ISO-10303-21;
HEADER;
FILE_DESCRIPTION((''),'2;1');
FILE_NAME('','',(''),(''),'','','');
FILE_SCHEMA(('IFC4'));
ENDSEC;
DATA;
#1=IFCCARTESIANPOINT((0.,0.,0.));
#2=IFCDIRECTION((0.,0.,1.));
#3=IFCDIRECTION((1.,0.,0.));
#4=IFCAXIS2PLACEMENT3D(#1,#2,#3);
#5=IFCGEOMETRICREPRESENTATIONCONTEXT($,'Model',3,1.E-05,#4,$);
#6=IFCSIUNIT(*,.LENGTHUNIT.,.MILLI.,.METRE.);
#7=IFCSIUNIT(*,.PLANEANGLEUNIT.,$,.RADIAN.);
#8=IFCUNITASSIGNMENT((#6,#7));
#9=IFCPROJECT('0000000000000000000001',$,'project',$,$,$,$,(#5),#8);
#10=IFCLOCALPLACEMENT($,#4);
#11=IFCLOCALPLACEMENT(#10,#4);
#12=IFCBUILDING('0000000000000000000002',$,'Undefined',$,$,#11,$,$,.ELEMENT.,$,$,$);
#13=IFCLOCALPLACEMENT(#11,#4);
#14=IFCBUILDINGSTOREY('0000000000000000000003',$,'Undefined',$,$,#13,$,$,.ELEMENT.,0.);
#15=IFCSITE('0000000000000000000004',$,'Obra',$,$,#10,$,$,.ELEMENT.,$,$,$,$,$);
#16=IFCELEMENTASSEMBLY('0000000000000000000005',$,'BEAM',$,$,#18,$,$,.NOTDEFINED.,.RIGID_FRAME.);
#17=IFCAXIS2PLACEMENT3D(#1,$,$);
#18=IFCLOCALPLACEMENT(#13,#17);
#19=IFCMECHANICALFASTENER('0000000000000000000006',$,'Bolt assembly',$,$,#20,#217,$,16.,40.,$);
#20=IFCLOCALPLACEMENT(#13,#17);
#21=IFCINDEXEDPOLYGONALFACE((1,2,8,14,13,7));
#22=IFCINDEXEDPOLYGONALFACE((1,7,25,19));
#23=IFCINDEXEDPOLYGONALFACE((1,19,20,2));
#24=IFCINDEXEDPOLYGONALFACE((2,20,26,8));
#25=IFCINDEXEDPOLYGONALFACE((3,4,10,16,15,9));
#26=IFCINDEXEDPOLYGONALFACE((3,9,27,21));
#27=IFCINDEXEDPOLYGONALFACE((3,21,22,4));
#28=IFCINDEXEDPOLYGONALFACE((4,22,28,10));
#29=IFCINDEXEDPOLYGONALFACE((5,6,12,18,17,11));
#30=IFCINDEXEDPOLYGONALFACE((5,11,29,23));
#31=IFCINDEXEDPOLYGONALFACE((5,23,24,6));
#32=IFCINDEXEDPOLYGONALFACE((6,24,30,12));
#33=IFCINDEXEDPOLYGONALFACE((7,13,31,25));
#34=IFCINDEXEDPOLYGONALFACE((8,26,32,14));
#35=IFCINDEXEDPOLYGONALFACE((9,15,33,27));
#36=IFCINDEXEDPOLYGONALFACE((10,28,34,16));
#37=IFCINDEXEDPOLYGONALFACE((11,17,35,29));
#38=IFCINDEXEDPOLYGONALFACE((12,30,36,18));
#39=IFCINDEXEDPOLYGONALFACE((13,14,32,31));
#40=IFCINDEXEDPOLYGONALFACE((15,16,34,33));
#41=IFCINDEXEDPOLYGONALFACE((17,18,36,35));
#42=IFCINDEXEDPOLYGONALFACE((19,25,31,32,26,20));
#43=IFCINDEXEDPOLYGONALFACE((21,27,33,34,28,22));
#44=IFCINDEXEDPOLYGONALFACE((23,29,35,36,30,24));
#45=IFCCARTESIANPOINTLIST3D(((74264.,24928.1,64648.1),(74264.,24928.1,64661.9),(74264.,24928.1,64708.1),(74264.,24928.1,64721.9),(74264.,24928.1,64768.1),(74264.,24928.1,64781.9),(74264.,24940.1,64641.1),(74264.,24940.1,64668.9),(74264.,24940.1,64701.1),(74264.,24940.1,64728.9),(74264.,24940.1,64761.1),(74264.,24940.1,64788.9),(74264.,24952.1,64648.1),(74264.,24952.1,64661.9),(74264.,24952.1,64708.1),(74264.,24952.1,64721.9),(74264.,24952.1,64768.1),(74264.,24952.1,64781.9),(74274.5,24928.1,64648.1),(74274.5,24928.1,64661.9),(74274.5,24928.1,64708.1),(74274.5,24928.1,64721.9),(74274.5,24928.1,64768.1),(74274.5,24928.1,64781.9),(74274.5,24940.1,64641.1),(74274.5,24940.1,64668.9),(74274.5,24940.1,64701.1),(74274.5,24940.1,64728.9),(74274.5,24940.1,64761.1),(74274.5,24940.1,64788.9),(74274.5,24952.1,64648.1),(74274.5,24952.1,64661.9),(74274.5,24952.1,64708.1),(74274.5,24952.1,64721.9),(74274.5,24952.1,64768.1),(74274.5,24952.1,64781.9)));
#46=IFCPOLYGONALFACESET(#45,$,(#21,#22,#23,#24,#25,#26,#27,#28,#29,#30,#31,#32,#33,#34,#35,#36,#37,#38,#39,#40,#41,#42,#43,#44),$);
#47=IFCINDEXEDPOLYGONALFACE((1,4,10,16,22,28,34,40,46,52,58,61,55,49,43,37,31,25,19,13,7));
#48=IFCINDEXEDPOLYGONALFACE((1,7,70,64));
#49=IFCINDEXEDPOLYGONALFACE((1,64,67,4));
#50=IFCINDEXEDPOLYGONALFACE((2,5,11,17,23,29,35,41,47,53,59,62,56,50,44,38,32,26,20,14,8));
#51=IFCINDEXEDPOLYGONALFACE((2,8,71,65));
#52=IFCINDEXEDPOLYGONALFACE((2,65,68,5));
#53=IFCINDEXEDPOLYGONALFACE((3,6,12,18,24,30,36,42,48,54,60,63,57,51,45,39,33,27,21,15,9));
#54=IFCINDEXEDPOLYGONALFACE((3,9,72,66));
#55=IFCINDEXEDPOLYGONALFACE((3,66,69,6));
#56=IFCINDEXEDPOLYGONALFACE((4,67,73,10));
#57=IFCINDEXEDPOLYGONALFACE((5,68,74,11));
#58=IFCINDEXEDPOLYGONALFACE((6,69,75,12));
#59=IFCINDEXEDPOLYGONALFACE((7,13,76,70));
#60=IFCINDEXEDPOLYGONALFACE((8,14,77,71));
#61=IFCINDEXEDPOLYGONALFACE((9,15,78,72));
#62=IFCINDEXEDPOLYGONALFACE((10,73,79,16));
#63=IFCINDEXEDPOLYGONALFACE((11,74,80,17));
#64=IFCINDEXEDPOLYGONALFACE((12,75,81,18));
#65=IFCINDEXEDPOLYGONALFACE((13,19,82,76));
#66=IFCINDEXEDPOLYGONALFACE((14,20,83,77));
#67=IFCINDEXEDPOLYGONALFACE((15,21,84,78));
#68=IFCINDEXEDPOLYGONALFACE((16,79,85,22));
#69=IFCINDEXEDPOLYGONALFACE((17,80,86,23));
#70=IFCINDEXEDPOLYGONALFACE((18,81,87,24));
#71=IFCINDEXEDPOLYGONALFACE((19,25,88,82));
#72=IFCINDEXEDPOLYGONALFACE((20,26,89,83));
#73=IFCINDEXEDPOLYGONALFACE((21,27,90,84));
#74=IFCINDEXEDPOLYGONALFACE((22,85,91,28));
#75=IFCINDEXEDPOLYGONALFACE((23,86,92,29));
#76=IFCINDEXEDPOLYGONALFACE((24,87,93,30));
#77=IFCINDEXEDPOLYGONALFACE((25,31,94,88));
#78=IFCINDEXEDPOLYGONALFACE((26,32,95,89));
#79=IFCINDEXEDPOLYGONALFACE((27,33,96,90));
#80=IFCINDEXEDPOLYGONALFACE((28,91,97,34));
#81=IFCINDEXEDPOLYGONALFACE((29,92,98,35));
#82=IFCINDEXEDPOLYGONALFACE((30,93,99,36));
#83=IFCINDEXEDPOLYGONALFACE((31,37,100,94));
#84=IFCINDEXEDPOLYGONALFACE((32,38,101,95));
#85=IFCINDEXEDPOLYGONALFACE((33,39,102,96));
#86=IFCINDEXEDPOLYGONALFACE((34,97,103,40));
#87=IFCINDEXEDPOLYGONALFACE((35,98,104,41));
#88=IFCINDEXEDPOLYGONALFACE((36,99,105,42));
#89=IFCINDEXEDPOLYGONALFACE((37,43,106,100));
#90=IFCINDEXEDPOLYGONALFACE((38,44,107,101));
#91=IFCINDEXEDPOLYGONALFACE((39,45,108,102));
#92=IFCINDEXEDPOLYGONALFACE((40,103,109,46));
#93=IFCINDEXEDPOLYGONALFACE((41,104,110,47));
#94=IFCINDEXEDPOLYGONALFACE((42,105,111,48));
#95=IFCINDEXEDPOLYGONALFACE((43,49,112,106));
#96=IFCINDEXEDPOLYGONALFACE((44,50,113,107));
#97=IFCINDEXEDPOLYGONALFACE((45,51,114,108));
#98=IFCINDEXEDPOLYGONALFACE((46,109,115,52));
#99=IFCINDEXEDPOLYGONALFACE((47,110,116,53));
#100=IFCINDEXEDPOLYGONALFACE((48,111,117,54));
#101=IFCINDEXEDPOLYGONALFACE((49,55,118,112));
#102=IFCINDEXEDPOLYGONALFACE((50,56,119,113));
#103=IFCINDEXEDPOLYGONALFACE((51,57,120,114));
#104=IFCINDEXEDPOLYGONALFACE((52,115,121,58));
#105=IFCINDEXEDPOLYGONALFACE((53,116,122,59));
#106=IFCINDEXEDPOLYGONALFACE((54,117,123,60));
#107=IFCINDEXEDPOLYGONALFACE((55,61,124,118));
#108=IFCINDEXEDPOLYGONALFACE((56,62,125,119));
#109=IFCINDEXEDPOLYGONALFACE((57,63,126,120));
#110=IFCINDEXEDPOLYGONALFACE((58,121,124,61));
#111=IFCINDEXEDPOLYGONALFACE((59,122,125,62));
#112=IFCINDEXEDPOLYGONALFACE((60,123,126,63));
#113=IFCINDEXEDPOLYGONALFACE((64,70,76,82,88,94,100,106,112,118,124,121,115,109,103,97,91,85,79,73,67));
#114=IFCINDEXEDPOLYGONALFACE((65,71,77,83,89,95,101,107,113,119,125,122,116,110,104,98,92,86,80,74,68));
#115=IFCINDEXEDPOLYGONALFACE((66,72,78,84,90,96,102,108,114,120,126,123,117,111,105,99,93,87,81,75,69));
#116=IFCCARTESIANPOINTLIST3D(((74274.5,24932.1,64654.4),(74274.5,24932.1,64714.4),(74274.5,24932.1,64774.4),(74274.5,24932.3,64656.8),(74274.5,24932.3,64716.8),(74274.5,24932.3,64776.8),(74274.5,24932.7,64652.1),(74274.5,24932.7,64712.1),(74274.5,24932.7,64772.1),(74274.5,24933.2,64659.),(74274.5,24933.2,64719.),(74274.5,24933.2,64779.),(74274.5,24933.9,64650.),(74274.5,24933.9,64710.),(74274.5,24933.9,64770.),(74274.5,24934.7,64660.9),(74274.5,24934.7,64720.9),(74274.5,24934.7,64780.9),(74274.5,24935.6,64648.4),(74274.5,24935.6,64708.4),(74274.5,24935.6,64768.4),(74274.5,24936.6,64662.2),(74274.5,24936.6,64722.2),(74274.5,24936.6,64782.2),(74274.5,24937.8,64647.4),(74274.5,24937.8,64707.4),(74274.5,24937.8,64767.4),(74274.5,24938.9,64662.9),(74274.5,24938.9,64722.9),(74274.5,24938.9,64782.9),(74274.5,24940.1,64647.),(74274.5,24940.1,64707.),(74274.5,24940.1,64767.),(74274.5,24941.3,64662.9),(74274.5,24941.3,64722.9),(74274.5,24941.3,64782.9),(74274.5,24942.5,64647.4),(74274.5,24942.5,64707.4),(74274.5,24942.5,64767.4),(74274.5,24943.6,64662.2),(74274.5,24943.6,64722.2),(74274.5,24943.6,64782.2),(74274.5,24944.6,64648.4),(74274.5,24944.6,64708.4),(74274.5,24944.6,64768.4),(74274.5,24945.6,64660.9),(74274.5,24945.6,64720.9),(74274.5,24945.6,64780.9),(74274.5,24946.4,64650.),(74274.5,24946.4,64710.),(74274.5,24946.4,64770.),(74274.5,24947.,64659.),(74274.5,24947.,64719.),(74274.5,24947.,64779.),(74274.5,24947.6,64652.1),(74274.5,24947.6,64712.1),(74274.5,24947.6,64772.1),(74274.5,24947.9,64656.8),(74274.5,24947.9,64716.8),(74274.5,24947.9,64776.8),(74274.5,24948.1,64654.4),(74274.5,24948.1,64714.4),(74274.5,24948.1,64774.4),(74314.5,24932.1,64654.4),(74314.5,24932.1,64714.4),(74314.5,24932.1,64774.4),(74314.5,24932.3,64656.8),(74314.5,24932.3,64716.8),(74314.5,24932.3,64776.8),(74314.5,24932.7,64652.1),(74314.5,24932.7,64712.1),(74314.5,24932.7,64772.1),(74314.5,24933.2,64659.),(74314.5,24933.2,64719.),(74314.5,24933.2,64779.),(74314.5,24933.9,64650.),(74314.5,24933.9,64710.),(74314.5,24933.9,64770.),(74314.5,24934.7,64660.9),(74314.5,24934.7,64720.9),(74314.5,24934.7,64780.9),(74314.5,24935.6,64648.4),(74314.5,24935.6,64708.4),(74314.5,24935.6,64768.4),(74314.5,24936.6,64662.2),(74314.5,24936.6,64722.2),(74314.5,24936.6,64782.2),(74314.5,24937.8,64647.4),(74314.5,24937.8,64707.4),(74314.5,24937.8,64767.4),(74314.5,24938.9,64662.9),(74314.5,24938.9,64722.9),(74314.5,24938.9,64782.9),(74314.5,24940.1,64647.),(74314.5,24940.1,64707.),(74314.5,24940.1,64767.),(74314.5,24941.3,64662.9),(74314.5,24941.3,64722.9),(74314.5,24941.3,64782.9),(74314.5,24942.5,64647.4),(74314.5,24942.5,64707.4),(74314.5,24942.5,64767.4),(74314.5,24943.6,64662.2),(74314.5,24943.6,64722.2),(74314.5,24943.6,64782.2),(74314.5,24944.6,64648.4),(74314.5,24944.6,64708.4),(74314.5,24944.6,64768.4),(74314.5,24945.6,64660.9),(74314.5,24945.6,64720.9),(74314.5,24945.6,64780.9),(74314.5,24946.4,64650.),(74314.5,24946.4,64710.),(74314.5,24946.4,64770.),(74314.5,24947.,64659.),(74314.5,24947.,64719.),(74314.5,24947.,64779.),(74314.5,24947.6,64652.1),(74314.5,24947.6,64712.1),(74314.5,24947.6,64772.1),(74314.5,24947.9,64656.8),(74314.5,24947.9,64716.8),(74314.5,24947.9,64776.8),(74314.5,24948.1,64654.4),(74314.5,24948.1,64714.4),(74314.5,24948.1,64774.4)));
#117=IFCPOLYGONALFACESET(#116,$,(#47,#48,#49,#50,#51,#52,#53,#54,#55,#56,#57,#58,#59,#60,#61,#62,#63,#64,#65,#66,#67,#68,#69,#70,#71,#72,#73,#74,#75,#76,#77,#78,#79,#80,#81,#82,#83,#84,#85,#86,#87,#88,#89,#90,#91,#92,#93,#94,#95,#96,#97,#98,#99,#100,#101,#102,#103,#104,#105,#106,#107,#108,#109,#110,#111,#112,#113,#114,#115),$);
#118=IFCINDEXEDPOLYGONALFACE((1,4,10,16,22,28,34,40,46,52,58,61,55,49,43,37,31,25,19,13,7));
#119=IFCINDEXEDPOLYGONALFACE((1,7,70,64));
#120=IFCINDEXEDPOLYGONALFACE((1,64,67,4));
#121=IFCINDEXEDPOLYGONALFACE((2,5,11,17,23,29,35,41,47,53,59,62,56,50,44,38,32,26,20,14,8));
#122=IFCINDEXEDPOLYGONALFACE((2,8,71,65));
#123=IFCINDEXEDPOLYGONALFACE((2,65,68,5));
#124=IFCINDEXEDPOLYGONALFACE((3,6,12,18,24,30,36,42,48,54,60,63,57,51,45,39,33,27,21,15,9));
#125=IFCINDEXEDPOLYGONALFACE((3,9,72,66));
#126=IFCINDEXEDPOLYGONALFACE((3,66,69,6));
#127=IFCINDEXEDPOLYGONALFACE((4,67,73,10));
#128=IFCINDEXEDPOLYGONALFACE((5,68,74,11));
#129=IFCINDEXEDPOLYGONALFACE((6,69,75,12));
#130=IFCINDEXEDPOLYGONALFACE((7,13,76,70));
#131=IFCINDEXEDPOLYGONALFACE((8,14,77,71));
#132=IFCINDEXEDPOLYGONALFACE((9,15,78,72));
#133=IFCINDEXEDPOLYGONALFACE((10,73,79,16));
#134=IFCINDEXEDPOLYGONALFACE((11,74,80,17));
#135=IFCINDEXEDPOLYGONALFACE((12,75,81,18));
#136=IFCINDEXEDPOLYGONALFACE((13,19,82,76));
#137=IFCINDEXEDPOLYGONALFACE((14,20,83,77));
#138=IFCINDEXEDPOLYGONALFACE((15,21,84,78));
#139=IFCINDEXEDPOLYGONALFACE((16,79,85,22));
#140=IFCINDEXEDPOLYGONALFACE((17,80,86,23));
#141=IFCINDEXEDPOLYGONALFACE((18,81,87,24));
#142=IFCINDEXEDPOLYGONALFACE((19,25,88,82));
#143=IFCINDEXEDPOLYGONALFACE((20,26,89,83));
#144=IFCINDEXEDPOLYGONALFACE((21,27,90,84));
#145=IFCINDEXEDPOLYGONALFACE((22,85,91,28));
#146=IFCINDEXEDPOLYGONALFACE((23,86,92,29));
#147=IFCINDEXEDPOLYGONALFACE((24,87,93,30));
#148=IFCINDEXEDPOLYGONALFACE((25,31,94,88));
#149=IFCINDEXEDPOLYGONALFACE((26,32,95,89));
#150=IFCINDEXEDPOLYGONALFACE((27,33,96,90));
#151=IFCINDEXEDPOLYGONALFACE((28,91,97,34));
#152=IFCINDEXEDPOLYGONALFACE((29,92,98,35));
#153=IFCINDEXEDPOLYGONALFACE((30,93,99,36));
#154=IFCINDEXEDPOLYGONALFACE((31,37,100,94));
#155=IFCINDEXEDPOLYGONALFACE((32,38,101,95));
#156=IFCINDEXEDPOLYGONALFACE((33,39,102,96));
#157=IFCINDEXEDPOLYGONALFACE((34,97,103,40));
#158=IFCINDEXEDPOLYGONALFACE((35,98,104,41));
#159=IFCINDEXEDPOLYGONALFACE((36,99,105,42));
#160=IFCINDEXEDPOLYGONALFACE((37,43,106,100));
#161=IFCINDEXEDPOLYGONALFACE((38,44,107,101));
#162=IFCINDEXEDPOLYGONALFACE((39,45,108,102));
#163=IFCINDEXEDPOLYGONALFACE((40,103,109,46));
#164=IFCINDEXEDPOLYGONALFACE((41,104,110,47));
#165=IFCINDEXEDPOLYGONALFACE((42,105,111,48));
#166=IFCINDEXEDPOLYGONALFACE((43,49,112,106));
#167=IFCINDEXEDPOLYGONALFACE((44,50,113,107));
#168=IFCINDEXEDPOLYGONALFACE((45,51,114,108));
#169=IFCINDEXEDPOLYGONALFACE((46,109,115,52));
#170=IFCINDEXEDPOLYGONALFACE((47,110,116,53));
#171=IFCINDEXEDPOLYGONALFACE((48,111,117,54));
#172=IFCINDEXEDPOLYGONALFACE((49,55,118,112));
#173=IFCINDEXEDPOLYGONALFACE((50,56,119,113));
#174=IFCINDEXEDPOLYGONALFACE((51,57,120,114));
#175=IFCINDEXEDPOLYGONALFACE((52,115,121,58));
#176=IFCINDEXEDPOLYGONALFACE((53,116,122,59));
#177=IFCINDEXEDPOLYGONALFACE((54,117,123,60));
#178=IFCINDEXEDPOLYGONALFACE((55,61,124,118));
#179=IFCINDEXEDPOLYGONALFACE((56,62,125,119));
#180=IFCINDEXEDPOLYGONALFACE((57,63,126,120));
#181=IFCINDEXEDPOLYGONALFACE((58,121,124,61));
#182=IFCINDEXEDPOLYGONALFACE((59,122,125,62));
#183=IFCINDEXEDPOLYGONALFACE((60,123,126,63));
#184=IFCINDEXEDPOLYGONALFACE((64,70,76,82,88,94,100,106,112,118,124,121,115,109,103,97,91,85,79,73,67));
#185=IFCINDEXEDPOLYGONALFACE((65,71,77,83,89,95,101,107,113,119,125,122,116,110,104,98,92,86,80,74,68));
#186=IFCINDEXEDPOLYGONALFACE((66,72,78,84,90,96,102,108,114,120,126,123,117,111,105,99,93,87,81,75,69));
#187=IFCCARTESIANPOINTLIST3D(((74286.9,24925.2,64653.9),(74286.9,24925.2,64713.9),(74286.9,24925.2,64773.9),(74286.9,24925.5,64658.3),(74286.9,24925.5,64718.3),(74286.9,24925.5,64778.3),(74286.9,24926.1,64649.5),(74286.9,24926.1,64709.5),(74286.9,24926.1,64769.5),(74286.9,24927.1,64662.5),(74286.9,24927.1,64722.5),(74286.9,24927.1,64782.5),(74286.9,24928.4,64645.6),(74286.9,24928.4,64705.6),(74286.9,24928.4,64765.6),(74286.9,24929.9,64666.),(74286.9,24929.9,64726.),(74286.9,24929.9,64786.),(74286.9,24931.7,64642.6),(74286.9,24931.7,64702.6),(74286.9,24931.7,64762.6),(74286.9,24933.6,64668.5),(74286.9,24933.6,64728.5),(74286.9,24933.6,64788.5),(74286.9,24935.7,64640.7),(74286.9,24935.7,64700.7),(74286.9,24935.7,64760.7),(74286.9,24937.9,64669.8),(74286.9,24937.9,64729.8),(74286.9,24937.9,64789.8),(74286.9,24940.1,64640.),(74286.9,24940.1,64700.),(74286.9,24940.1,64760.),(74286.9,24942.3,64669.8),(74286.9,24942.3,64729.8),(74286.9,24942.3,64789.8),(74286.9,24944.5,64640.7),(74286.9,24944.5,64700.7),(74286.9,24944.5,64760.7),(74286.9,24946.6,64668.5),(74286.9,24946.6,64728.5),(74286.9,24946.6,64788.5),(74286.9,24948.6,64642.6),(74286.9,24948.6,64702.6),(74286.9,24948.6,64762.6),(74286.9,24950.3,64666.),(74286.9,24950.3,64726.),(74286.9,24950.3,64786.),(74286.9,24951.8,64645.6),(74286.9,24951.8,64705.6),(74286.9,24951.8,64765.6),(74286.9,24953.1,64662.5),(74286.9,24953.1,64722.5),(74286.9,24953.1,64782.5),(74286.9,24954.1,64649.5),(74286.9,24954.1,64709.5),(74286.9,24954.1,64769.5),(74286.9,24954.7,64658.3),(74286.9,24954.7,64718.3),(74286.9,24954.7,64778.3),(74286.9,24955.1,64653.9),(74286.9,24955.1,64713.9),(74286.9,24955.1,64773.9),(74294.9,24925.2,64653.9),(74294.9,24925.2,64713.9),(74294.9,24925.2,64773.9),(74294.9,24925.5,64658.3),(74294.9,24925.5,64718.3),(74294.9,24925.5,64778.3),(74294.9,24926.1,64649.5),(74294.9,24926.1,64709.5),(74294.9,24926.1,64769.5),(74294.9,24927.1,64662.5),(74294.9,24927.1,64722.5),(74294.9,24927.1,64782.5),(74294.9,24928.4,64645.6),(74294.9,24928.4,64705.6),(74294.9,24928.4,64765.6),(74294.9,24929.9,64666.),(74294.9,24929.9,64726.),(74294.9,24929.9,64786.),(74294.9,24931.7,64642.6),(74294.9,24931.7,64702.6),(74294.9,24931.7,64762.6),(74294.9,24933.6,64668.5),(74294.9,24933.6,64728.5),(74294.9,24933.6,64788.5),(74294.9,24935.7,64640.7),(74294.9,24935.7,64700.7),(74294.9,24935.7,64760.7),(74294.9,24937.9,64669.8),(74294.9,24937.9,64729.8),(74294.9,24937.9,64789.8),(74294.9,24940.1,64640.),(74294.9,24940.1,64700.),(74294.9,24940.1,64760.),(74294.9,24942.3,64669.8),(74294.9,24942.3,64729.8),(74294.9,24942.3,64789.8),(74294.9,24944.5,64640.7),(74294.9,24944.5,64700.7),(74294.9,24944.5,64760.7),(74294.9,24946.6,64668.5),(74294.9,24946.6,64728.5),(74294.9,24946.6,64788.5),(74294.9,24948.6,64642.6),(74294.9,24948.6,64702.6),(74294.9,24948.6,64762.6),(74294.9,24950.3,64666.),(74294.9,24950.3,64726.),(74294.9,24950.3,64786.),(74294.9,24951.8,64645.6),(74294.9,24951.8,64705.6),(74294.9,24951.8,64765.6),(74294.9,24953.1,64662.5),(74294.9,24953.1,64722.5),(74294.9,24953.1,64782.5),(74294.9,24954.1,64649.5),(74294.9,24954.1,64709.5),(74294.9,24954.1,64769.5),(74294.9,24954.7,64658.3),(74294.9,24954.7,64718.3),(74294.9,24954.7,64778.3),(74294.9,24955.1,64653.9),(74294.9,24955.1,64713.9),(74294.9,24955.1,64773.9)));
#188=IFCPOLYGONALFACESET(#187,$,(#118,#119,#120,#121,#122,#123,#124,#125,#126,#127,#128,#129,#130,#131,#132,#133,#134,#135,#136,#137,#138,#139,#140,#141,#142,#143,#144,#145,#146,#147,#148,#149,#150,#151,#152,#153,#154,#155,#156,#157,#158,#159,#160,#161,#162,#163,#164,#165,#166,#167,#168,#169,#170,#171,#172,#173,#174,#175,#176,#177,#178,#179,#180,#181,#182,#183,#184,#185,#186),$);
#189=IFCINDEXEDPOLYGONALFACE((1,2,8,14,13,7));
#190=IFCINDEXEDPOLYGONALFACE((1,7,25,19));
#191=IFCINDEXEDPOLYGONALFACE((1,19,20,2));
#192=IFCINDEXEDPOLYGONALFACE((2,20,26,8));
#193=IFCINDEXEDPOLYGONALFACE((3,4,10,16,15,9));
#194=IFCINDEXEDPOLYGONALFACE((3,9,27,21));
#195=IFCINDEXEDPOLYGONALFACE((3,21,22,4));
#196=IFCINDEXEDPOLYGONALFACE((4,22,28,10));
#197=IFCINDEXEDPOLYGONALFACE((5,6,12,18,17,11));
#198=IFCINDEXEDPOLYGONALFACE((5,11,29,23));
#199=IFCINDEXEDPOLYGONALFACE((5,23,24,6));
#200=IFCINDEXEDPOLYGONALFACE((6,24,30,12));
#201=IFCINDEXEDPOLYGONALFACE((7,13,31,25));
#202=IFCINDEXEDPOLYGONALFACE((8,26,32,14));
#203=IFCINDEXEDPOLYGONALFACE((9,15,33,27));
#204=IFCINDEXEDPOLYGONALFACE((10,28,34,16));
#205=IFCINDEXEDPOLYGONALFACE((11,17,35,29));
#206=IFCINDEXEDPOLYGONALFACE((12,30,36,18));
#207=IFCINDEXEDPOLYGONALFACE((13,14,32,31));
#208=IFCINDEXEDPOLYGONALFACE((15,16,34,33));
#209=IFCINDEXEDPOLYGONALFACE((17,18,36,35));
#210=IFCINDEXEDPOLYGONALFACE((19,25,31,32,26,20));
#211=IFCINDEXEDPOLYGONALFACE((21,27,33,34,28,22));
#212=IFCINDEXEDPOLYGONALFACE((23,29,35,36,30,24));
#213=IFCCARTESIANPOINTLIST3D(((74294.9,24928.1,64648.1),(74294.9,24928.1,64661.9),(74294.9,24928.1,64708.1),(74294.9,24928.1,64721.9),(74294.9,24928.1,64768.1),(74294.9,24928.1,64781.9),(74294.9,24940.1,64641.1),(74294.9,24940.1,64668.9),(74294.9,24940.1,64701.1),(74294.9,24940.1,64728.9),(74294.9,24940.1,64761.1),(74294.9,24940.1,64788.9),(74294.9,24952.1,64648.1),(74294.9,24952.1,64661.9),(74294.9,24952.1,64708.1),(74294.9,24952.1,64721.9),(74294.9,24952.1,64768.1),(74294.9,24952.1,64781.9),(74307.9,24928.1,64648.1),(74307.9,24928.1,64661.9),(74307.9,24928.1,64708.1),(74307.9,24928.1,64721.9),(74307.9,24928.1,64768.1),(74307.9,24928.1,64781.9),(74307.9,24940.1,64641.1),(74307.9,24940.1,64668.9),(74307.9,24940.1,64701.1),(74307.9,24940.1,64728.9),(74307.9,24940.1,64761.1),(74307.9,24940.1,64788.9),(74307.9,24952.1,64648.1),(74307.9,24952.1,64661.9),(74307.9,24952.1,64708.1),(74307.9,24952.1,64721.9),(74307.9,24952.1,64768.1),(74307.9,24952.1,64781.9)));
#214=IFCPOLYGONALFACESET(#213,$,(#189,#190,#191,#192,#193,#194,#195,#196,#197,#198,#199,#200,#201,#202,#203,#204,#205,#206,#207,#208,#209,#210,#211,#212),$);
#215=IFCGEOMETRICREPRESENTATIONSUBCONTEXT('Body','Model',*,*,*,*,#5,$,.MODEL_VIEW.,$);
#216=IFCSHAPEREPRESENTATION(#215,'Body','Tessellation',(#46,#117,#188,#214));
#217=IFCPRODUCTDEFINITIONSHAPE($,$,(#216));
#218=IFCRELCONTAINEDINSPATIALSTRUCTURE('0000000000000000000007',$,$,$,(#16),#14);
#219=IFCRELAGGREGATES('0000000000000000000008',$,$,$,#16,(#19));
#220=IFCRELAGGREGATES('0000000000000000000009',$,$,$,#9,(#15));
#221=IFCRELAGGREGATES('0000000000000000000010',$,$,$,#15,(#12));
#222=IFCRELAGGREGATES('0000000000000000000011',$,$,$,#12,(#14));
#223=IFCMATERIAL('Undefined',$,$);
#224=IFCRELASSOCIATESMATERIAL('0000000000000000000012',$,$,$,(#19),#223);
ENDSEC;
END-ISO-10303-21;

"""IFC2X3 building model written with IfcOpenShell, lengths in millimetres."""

from ifc_helpers import new_model, si_unit, frame, origin_with_axes, origin_2d_with_axis, place, context, subcontext, project, spatial, polyline, circle, outline, extrude, source, transform, mapped, material, element, aggregate, save


model = new_model("IFC2X3")

# Units and contexts
model_context = context("Model", 3, precision=1e-05, world=origin_with_axes())
body_context = subcontext(model_context, "Body", "Model", "MODEL_VIEW")
ifc_project = project(units=[si_unit("LENGTHUNIT", "METRE", prefix="MILLI"), si_unit("PLANEANGLEUNIT", "RADIAN")], contexts=[model_context])

# Site, building, storey
site_placement = place(None, origin_with_axes())
site = spatial("IfcSite", under=ifc_project, at=site_placement, Name="Obra", CompositionType="ELEMENT")
building_placement = place(site_placement, origin_with_axes())
building = spatial("IfcBuilding", under=site, at=building_placement, Name="Undefined", CompositionType="ELEMENT")
storey_placement = place(building_placement, origin_with_axes())
storey = spatial("IfcBuildingStorey", under=building, at=storey_placement, Name="Undefined", CompositionType="ELEMENT", Elevation=0.0)

# Element assembly, mechanical fastener
ifc_material_1 = material(Name="Undefined")
assembly_1_placement = place(storey_placement, origin_with_axes())
assembly_1 = element("IfcElementAssembly", 1, at=assembly_1_placement, inside=storey, Name="BEAM", AssemblyPlace="NOTDEFINED", PredefinedType="RIGID_FRAME")
shared_shape_1 = source(origin_with_axes(), body_context, "Body", "SweptSolid", [
    extrude(outline(polyline([(13.9, 0.0), (6.9, 12.0), (-6.9, 12.0), (-13.9, 0.0), (-6.9, -12.0), (6.9, -12.0), (13.9, 0.0)])), frame((0.0, -19.7, 0.0), z_axis=(0.0, 1.0, 0.0), x_axis=(1.0, 0.0, 0.0)), (0.0, 0.0, 1.0), 10.6),
    extrude(circle(Radius=8.0, at=origin_2d_with_axis()), frame((0.0, -9.1, 0.0), z_axis=(0.0, 1.0, 0.0), x_axis=(1.0, 0.0, 0.0)), (0.0, 0.0, 1.0), 40.0),
    extrude(circle(Radius=15.0, at=origin_2d_with_axis()), frame((0.0, 3.3, 0.0), z_axis=(0.0, 1.0, 0.0), x_axis=(1.0, 0.0, 0.0)), (0.0, 0.0, 1.0), 8.0),
    extrude(outline(polyline([(13.9, 0.0), (6.9, 12.0), (-6.9, 12.0), (-13.9, 0.0), (-6.9, -12.0), (6.9, -12.0), (13.9, 0.0)])), frame((0.0, 11.3, 0.0), z_axis=(0.0, 1.0, 0.0), x_axis=(1.0, 0.0, 0.0)), (0.0, 0.0, 1.0), 13.0),
])
mechanical_fastener_1_placement = place(assembly_1_placement, frame((74283.6, 24990.1, 64835.0), z_axis=(0.000002, -1.0, 0.0), x_axis=(0.0, 0.0, -1.0)))
mechanical_fastener_1 = element("IfcMechanicalFastener", 2, at=mechanical_fastener_1_placement, material=ifc_material_1, Name="Bolt assembly", NominalDiameter=16.0, NominalLength=40.0, context=body_context, shape_type="MappedRepresentation", body=[
    mapped(shared_shape_1, transform((60.0, 0.0, 50.0))),
    mapped(shared_shape_1, transform((120.0, 0.0, 50.0))),
    mapped(shared_shape_1, transform((180.0, 0.0, 50.0))),
])
aggregate(assembly_1, [mechanical_fastener_1])

save(model, "model.ifc")
